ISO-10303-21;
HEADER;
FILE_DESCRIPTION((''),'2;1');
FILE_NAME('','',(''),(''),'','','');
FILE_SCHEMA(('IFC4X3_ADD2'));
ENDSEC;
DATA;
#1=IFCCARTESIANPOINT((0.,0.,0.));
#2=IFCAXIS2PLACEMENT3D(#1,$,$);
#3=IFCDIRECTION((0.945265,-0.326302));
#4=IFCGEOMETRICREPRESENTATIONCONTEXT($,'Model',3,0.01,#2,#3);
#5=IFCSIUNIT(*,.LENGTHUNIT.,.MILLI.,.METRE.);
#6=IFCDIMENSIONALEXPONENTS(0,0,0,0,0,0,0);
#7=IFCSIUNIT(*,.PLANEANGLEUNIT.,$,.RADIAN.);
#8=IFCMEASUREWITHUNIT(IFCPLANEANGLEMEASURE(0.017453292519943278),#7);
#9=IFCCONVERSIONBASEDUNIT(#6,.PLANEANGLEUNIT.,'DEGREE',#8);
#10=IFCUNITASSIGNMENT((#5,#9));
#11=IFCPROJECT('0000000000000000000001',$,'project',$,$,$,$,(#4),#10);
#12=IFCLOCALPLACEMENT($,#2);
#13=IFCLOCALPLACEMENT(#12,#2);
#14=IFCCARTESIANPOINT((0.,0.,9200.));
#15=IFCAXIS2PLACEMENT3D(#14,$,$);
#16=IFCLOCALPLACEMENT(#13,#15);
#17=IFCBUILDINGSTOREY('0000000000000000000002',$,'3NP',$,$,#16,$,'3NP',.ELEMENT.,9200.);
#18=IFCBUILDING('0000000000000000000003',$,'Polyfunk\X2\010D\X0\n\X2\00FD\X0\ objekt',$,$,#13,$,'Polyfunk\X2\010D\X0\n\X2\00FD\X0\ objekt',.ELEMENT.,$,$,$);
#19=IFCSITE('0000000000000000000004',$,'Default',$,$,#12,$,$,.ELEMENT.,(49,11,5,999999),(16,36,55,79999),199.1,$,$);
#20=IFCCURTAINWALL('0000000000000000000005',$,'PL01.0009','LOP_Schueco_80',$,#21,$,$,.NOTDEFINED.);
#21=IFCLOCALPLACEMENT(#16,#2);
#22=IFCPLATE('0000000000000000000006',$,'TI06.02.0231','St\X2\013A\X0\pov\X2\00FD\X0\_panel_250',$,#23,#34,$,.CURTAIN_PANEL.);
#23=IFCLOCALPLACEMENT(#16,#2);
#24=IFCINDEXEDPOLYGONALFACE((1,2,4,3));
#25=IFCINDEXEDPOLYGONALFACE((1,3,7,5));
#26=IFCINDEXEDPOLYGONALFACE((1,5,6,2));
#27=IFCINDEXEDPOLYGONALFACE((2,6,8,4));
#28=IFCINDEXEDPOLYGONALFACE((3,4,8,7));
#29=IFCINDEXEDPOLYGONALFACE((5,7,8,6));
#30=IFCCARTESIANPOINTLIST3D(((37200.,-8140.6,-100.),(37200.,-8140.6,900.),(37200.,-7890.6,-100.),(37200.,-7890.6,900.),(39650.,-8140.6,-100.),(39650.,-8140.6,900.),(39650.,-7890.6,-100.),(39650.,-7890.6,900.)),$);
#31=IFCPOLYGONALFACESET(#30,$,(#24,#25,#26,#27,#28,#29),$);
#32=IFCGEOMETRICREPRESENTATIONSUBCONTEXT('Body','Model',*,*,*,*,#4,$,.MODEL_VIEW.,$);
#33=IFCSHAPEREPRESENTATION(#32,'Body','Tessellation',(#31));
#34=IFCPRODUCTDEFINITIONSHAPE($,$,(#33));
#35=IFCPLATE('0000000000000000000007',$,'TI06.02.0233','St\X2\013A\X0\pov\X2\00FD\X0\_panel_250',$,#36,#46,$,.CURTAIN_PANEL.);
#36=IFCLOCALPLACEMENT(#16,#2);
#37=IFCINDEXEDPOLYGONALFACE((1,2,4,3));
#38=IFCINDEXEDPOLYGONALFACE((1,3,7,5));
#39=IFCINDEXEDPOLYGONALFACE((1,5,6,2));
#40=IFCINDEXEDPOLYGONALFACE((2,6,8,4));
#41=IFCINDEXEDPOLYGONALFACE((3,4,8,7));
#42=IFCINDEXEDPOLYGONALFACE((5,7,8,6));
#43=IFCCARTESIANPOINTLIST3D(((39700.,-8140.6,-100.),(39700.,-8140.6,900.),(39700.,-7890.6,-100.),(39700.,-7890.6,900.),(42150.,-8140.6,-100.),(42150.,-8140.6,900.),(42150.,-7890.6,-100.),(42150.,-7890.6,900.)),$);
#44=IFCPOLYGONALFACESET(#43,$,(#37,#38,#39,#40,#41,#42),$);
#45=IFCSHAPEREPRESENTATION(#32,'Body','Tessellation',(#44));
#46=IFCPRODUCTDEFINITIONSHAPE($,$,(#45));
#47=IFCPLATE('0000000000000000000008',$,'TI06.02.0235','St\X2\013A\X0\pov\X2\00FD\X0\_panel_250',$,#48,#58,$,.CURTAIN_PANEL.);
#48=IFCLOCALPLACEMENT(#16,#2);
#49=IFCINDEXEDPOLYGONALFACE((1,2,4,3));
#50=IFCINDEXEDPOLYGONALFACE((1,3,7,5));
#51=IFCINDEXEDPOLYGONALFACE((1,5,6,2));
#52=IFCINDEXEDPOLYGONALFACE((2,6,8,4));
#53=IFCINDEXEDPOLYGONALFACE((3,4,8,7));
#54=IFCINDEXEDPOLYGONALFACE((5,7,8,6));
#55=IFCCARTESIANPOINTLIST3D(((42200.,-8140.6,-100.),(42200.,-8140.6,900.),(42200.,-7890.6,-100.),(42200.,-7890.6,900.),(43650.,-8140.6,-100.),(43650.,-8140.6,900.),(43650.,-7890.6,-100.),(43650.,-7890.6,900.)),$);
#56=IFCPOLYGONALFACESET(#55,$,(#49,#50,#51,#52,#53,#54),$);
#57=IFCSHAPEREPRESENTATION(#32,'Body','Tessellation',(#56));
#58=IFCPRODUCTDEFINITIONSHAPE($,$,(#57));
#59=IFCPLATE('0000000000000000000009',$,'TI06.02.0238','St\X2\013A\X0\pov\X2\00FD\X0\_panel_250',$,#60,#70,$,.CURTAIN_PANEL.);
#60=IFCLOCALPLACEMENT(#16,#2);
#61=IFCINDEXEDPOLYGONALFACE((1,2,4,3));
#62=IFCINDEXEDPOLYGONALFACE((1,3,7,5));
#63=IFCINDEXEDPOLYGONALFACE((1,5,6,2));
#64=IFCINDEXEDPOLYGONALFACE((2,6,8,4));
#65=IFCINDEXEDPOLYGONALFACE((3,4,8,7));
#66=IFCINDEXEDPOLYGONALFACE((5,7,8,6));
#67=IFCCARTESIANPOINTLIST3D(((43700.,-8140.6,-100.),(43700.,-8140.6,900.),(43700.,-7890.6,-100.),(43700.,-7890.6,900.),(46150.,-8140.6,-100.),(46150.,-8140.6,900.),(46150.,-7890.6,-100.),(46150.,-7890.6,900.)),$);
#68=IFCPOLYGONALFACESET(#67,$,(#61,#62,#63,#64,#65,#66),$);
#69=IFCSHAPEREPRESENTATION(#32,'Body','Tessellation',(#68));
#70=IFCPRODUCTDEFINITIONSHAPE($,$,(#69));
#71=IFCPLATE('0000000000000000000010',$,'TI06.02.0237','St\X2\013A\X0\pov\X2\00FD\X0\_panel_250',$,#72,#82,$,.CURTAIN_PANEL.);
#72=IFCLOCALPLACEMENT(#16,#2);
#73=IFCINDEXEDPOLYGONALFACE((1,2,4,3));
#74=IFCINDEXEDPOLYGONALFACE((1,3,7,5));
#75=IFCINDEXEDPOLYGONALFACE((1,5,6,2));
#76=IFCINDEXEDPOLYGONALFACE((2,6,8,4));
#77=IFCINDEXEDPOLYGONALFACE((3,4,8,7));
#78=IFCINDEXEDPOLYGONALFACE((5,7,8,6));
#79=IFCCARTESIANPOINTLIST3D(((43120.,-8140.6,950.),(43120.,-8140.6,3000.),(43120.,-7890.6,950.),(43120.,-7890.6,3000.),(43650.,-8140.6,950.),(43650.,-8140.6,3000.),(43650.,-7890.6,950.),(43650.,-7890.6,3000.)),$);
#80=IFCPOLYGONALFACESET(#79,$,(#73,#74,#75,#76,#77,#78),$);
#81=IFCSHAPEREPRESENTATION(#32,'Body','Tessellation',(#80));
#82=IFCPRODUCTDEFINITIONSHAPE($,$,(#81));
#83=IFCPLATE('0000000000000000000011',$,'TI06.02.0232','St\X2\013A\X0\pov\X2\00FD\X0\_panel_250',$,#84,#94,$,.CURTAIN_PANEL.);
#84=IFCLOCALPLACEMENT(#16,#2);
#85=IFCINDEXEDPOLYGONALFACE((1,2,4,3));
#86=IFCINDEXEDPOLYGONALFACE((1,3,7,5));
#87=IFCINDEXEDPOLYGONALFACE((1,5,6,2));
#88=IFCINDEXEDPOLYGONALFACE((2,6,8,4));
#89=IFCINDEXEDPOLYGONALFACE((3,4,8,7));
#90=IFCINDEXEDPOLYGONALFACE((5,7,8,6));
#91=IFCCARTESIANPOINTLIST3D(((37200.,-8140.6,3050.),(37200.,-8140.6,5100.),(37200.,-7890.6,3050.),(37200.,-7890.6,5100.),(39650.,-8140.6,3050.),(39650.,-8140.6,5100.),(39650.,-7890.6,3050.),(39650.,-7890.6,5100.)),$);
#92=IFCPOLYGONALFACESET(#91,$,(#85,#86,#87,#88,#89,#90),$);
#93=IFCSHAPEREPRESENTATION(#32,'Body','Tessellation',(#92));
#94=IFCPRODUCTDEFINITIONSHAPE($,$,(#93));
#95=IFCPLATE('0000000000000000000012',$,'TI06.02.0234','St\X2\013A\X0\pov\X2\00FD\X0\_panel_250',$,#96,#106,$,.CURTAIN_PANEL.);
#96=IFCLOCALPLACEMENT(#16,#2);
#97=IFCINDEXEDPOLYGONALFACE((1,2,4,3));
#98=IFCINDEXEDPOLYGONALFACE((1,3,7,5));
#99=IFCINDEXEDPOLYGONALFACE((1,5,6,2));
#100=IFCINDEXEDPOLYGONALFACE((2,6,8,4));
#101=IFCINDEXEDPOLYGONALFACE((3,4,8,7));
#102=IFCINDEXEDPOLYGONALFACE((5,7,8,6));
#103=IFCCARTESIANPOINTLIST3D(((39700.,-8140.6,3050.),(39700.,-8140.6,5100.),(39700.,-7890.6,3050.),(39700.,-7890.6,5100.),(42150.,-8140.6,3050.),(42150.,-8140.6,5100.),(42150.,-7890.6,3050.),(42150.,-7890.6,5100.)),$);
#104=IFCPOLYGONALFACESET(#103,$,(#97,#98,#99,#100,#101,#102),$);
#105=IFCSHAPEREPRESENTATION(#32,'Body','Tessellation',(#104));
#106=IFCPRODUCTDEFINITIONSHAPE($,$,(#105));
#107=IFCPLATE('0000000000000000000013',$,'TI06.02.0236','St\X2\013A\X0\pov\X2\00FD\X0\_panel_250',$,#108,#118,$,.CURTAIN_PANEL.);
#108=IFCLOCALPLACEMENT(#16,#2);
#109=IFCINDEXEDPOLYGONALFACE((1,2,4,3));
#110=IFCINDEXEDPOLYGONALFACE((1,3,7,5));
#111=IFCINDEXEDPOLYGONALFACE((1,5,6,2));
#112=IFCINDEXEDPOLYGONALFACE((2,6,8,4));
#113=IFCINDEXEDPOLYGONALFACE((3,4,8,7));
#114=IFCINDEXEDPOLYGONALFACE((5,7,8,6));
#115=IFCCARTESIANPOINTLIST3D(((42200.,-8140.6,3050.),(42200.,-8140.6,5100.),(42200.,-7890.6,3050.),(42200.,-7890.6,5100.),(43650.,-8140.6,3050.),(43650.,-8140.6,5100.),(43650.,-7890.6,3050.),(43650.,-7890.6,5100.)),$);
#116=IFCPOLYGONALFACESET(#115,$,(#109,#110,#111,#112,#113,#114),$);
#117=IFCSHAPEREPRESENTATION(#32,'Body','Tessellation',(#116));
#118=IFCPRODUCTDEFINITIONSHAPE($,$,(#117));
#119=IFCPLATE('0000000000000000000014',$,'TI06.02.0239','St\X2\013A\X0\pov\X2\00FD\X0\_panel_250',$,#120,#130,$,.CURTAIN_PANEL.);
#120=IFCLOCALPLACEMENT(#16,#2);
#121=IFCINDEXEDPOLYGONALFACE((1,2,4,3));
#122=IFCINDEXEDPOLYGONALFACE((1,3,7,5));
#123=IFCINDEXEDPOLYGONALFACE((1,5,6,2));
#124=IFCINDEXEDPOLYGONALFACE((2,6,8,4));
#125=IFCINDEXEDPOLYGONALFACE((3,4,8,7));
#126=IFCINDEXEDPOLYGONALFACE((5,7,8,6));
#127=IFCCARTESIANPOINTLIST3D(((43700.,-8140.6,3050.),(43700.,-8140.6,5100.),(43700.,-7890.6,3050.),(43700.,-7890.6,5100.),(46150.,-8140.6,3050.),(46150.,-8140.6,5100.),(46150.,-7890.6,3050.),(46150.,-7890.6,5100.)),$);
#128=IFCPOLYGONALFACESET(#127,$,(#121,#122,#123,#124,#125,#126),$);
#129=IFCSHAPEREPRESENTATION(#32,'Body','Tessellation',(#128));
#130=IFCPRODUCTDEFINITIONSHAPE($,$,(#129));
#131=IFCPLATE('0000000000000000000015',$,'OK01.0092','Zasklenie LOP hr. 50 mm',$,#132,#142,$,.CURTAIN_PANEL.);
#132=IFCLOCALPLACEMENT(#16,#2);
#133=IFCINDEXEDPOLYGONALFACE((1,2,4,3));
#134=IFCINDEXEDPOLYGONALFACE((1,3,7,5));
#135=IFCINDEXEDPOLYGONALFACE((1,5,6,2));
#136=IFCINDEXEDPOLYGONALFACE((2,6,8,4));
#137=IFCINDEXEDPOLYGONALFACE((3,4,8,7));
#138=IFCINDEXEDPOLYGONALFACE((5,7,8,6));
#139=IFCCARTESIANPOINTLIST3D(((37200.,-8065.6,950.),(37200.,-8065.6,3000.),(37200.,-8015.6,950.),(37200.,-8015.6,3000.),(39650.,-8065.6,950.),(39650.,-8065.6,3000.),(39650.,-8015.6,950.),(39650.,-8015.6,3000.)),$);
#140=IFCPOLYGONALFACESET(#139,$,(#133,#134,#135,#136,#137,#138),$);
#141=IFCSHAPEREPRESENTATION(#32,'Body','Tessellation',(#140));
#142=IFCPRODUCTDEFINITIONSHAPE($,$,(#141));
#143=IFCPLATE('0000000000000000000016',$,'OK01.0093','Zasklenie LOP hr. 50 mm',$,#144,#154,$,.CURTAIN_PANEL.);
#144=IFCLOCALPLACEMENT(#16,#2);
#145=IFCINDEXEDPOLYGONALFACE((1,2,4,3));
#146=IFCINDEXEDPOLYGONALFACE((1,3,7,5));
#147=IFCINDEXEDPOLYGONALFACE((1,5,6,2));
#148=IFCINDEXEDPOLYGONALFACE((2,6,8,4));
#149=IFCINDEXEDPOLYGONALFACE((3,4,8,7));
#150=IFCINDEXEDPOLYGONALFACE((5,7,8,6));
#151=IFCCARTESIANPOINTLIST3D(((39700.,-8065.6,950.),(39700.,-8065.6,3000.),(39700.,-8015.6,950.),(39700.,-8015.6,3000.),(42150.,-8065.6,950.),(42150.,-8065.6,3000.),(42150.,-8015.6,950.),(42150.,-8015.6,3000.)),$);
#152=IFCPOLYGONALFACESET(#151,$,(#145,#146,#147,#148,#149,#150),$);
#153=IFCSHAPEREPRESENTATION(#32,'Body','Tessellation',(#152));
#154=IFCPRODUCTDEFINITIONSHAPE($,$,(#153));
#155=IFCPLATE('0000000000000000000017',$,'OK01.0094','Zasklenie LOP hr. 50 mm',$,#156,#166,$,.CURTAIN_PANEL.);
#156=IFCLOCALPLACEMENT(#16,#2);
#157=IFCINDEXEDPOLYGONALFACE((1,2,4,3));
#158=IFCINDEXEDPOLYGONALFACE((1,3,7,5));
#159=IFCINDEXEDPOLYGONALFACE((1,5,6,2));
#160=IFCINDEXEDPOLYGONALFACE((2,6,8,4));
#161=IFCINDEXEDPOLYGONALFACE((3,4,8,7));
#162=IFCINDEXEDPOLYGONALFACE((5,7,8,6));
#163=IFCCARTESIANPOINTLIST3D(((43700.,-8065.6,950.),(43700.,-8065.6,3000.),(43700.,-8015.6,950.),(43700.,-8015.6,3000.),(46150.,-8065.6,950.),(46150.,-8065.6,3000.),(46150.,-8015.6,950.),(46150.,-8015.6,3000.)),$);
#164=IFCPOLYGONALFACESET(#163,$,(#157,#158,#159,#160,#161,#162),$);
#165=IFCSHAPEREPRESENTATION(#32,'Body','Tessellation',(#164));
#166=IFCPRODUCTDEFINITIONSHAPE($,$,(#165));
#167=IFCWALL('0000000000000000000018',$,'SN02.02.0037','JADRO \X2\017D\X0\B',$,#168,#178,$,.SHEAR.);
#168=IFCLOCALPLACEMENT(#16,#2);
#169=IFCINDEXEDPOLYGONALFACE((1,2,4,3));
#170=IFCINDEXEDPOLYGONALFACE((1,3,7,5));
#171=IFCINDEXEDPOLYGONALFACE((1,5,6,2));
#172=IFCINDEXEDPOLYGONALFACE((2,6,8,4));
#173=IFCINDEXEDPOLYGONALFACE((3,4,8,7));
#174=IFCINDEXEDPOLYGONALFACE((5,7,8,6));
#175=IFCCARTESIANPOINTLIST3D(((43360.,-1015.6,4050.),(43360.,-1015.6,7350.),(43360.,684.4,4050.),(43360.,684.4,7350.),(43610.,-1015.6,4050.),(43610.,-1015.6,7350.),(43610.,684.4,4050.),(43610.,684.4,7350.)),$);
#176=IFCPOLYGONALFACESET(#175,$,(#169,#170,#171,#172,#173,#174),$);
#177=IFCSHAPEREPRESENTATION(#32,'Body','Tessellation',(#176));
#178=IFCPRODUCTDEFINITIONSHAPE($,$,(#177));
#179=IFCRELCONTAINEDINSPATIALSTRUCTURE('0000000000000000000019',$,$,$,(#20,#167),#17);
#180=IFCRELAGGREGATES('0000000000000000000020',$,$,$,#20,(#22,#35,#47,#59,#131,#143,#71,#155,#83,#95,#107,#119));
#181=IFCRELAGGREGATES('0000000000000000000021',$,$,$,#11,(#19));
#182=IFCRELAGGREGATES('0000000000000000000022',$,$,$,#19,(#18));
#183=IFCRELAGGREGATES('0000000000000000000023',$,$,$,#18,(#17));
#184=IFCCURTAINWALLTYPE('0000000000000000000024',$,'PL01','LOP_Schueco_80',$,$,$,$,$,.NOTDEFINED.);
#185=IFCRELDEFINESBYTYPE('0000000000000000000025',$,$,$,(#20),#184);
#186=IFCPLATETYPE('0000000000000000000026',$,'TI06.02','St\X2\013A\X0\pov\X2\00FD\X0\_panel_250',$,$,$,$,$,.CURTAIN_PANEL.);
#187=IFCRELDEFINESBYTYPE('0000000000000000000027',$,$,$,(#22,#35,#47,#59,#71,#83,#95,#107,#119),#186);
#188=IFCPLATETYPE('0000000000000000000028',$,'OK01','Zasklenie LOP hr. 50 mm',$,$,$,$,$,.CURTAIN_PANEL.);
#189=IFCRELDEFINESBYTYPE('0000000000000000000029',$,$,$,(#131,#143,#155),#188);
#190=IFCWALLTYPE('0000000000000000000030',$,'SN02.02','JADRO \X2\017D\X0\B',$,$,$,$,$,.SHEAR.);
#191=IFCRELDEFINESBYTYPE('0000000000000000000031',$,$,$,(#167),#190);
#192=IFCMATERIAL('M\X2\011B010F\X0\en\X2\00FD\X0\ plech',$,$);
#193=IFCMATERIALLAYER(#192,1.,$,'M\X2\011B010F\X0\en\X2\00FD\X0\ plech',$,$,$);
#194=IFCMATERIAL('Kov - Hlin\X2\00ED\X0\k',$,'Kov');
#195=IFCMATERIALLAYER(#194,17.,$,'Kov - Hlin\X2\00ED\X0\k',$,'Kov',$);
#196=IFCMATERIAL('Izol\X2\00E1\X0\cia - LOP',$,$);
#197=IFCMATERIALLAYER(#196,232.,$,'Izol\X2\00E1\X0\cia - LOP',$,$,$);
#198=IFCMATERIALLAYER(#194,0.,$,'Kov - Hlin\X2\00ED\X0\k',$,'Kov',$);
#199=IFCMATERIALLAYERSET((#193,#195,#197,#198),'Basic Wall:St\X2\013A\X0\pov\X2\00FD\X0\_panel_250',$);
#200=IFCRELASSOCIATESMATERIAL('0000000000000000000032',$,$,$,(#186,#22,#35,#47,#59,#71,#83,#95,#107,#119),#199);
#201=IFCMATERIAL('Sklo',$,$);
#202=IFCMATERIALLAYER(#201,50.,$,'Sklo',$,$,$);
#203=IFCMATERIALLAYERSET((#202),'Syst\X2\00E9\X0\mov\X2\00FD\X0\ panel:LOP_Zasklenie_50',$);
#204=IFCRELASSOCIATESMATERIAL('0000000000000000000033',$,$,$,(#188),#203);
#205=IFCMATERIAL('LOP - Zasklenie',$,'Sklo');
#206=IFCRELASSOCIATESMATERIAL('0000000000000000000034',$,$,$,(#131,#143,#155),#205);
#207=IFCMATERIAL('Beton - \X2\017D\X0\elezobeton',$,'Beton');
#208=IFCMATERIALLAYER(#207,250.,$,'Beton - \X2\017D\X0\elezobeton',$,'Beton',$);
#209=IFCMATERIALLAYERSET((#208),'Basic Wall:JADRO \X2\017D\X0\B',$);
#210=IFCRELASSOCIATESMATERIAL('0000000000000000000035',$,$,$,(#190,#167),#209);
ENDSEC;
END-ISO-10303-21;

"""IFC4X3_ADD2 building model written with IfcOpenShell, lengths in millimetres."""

from ifc_helpers import new_model, entity, si_unit, converted_unit, direction, frame, frame_2d, origin, origin_2d_with_axis, place, context, subcontext, project, spatial, polyline, rectangle, extrude, clip, bounded_halfspace, source, transform, mapped, material, layer, layer_set, layer_usage, type_object, type_shapes, element, aggregate, save


model = new_model("IFC4X3_ADD2")

# Units and contexts
model_context = context("Model", 3, precision=0.01, world=origin(), true_north=direction((0.945265, -0.326302)))
body_context = subcontext(model_context, "Body", "Model", "MODEL_VIEW")
ifc_project = project(units=[si_unit("LENGTHUNIT", "METRE", prefix="MILLI"), converted_unit("PLANEANGLEUNIT", "DEGREE", entity("IfcPlaneAngleMeasure", 0.017453292519943278), si_unit("PLANEANGLEUNIT", "RADIAN"), dimensions=[0, 0, 0, 0, 0, 0, 0])], contexts=[model_context])

# Site, building, storey
site_placement = place(None, origin())
site = spatial("IfcSite", under=ifc_project, at=site_placement, Name="Default", CompositionType="ELEMENT", RefLatitude=(49, 11, 5, 999999), RefLongitude=(16, 36, 55, 79999), RefElevation=199.1)
building_placement = place(site_placement, origin())
building = spatial("IfcBuilding", under=site, at=building_placement, Name="Polyfunkčný objekt", LongName="Polyfunkčný objekt", CompositionType="ELEMENT")
storey_placement = place(building_placement, frame((0.0, 0.0, 9200.0)))
storey = spatial("IfcBuildingStorey", under=building, at=storey_placement, Name="3NP", LongName="3NP", CompositionType="ELEMENT", Elevation=9200.0)

# Curtain wall, plates
curtain_wall_type = type_object("IfcCurtainWallType", Name="PL01", Description="LOP_Schueco_80", PredefinedType="NOTDEFINED")
curtain_wall_placement = place(storey_placement, frame((0.0, 0.0, -9200.0)))
curtain_wall = element("IfcCurtainWall", 1, at=curtain_wall_placement, inside=storey, type_object=curtain_wall_type, Name="PL01.0009", Description="LOP_Schueco_80", PredefinedType="NOTDEFINED")
ifc_material_1 = material(Name="Měďený plech")
ifc_layer_1 = layer(ifc_material_1, 1.0, Name="Měďený plech")
ifc_material_2 = material(Name="Kov - Hliník", Category="Kov")
ifc_layer_2 = layer(ifc_material_2, 17.0, Name="Kov - Hliník", Category="Kov")
ifc_material_3 = material(Name="Izolácia - LOP")
ifc_layer_3 = layer(ifc_material_3, 232.0, Name="Izolácia - LOP")
ifc_layer_4 = layer(ifc_material_2, 0.0, Name="Kov - Hliník", Category="Kov")
ifc_layer_set_1 = layer_set([ifc_layer_1, ifc_layer_2, ifc_layer_3, ifc_layer_4], Name="Basic Wall:Stĺpový_panel_250")
ifc_layer_usage_1 = layer_usage(ifc_layer_set_1, "AXIS2", "POSITIVE", -125.0)
plate_type_1 = type_object("IfcPlateType", Name="TI06.02", Description="Stĺpový_panel_250", PredefinedType="CURTAIN_PANEL", material=ifc_layer_set_1)
plate_1_placement = place(storey_placement, frame((37200.0, -8015.6, -100.0)))
plate_1 = element("IfcPlate", 2, at=plate_1_placement, type_object=plate_type_1, material=ifc_layer_usage_1, Name="TI06.02.0231", Description="Stĺpový_panel_250", PredefinedType="CURTAIN_PANEL", context=body_context, shape_type="SweptSolid", body=[
    extrude(rectangle(XDim=250.0, YDim=2450.0, at=frame_2d((0.0, 0.0), x_axis=(1.0, 0.0))), frame((1225.0, 0.0, 0.0), z_axis=(0.0, 0.0, 1.0), x_axis=(0.0, 1.0, 0.0)), (0.0, 0.0, 1.0), 1000.0),
])
ifc_layer_usage_2 = layer_usage(ifc_layer_set_1, "AXIS2", "POSITIVE", -125.0)
plate_2_placement = place(storey_placement, frame((39700.0, -8015.6, -100.0)))
plate_2 = element("IfcPlate", 3, at=plate_2_placement, type_object=plate_type_1, material=ifc_layer_usage_2, Name="TI06.02.0233", Description="Stĺpový_panel_250", PredefinedType="CURTAIN_PANEL", context=body_context, shape_type="SweptSolid", body=[
    extrude(rectangle(XDim=250.0, YDim=2450.0, at=frame_2d((0.0, 0.0), x_axis=(1.0, 0.0))), frame((1225.0, 0.0, 0.0), z_axis=(0.0, 0.0, 1.0), x_axis=(0.0, 1.0, 0.0)), (0.0, 0.0, 1.0), 1000.0),
])
ifc_layer_usage_3 = layer_usage(ifc_layer_set_1, "AXIS2", "POSITIVE", -125.0)
plate_3_placement = place(storey_placement, frame((42200.0, -8015.6, -100.0)))
plate_3 = element("IfcPlate", 4, at=plate_3_placement, type_object=plate_type_1, material=ifc_layer_usage_3, Name="TI06.02.0235", Description="Stĺpový_panel_250", PredefinedType="CURTAIN_PANEL", context=body_context, shape_type="SweptSolid", body=[
    extrude(rectangle(XDim=250.0, YDim=1450.0, at=frame_2d((0.0, 0.0), x_axis=(1.0, 0.0))), frame((725.0, 0.0, 0.0), z_axis=(0.0, 0.0, 1.0), x_axis=(0.0, 1.0, 0.0)), (0.0, 0.0, 1.0), 1000.0),
])
ifc_layer_usage_4 = layer_usage(ifc_layer_set_1, "AXIS2", "POSITIVE", -125.0)
plate_4_placement = place(storey_placement, frame((43700.0, -8015.6, -100.0)))
plate_4 = element("IfcPlate", 5, at=plate_4_placement, type_object=plate_type_1, material=ifc_layer_usage_4, Name="TI06.02.0238", Description="Stĺpový_panel_250", PredefinedType="CURTAIN_PANEL", context=body_context, shape_type="SweptSolid", body=[
    extrude(rectangle(XDim=250.0, YDim=2450.0, at=frame_2d((0.0, 0.0), x_axis=(1.0, 0.0))), frame((1225.0, 0.0, 0.0), z_axis=(0.0, 0.0, 1.0), x_axis=(0.0, 1.0, 0.0)), (0.0, 0.0, 1.0), 1000.0),
])
ifc_layer_usage_5 = layer_usage(ifc_layer_set_1, "AXIS2", "POSITIVE", -125.0)
plate_5_placement = place(storey_placement, frame((43120.0, -8015.6, 950.0)))
plate_5 = element("IfcPlate", 6, at=plate_5_placement, type_object=plate_type_1, material=ifc_layer_usage_5, Name="TI06.02.0237", Description="Stĺpový_panel_250", PredefinedType="CURTAIN_PANEL", context=body_context, shape_type="SweptSolid", body=[
    extrude(rectangle(XDim=250.0, YDim=530.0, at=frame_2d((0.0, 0.0), x_axis=(1.0, 0.0))), frame((265.0, 0.0, 0.0), z_axis=(0.0, 0.0, 1.0), x_axis=(0.0, 1.0, 0.0)), (0.0, 0.0, 1.0), 2050.0),
])
ifc_layer_usage_6 = layer_usage(ifc_layer_set_1, "AXIS2", "POSITIVE", -125.0)
plate_6_placement = place(storey_placement, frame((37200.0, -8015.6, 3050.0)))
plate_6 = element("IfcPlate", 7, at=plate_6_placement, type_object=plate_type_1, material=ifc_layer_usage_6, Name="TI06.02.0232", Description="Stĺpový_panel_250", PredefinedType="CURTAIN_PANEL", context=body_context, shape_type="SweptSolid", body=[
    extrude(rectangle(XDim=250.0, YDim=2450.0, at=frame_2d((0.0, 0.0), x_axis=(1.0, 0.0))), frame((1225.0, 0.0, 0.0), z_axis=(0.0, 0.0, 1.0), x_axis=(0.0, 1.0, 0.0)), (0.0, 0.0, 1.0), 2050.0),
])
ifc_layer_usage_7 = layer_usage(ifc_layer_set_1, "AXIS2", "POSITIVE", -125.0)
plate_7_placement = place(storey_placement, frame((39700.0, -8015.6, 3050.0)))
plate_7 = element("IfcPlate", 8, at=plate_7_placement, type_object=plate_type_1, material=ifc_layer_usage_7, Name="TI06.02.0234", Description="Stĺpový_panel_250", PredefinedType="CURTAIN_PANEL", context=body_context, shape_type="SweptSolid", body=[
    extrude(rectangle(XDim=250.0, YDim=2450.0, at=frame_2d((0.0, 0.0), x_axis=(1.0, 0.0))), frame((1225.0, 0.0, 0.0), z_axis=(0.0, 0.0, 1.0), x_axis=(0.0, 1.0, 0.0)), (0.0, 0.0, 1.0), 2050.0),
])
ifc_layer_usage_8 = layer_usage(ifc_layer_set_1, "AXIS2", "POSITIVE", -125.0)
plate_8_placement = place(storey_placement, frame((42200.0, -8015.6, 3050.0)))
plate_8 = element("IfcPlate", 9, at=plate_8_placement, type_object=plate_type_1, material=ifc_layer_usage_8, Name="TI06.02.0236", Description="Stĺpový_panel_250", PredefinedType="CURTAIN_PANEL", context=body_context, shape_type="SweptSolid", body=[
    extrude(rectangle(XDim=250.0, YDim=1450.0, at=frame_2d((0.0, 0.0), x_axis=(1.0, 0.0))), frame((725.0, 0.0, 0.0), z_axis=(0.0, 0.0, 1.0), x_axis=(0.0, 1.0, 0.0)), (0.0, 0.0, 1.0), 2050.0),
])
ifc_layer_usage_9 = layer_usage(ifc_layer_set_1, "AXIS2", "POSITIVE", -125.0)
plate_9_placement = place(storey_placement, frame((43700.0, -8015.6, 3050.0)))
plate_9 = element("IfcPlate", 10, at=plate_9_placement, type_object=plate_type_1, material=ifc_layer_usage_9, Name="TI06.02.0239", Description="Stĺpový_panel_250", PredefinedType="CURTAIN_PANEL", context=body_context, shape_type="SweptSolid", body=[
    extrude(rectangle(XDim=250.0, YDim=2450.0, at=frame_2d((0.0, 0.0), x_axis=(1.0, 0.0))), frame((1225.0, 0.0, 0.0), z_axis=(0.0, 0.0, 1.0), x_axis=(0.0, 1.0, 0.0)), (0.0, 0.0, 1.0), 2050.0),
])
ifc_material_4 = material(Name="LOP - Zasklenie", Category="Sklo")
ifc_material_5 = material(Name="Sklo")
ifc_layer_5 = layer(ifc_material_5, 50.0, Name="Sklo")
ifc_layer_set_2 = layer_set([ifc_layer_5], Name="Systémový panel:LOP_Zasklenie_50")
plate_type_2 = type_object("IfcPlateType", Name="OK01", Description="Zasklenie LOP hr. 50 mm", PredefinedType="CURTAIN_PANEL", material=ifc_layer_set_2)
shared_shape_1 = source(origin(), body_context, "Body", "SweptSolid", [
    extrude(rectangle(XDim=50.0, YDim=2450.0, at=origin_2d_with_axis()), frame((0.0, -25.0, 0.0), z_axis=(0.0, 0.0, 1.0), x_axis=(0.0, 1.0, 0.0)), (0.0, 0.0, 1.0), 2050.0),
])
type_shapes(plate_type_2, [shared_shape_1])
plate_10_placement = place(curtain_wall_placement, frame((38425.0, -8015.6, 10150.0)))
plate_10 = element("IfcPlate", 11, at=plate_10_placement, type_object=plate_type_2, material=ifc_material_4, Name="OK01.0092", Description="Zasklenie LOP hr. 50 mm", PredefinedType="CURTAIN_PANEL", context=body_context, shape_type="MappedRepresentation", body=[
    mapped(shared_shape_1, transform((0.0, 0.0, 0.0), scale=1.0)),
])
plate_11_placement = place(curtain_wall_placement, frame((40925.0, -8015.6, 10150.0)))
plate_11 = element("IfcPlate", 12, at=plate_11_placement, type_object=plate_type_2, material=ifc_material_4, Name="OK01.0093", Description="Zasklenie LOP hr. 50 mm", PredefinedType="CURTAIN_PANEL", context=body_context, shape_type="MappedRepresentation", body=[
    mapped(shared_shape_1, transform((0.0, 0.0, 0.0), scale=1.0)),
])
plate_12_placement = place(curtain_wall_placement, frame((44925.0, -8015.6, 10150.0)))
plate_12 = element("IfcPlate", 13, at=plate_12_placement, type_object=plate_type_2, material=ifc_material_4, Name="OK01.0094", Description="Zasklenie LOP hr. 50 mm", PredefinedType="CURTAIN_PANEL", context=body_context, shape_type="MappedRepresentation", body=[
    mapped(shared_shape_1, transform((0.0, 0.0, 0.0), scale=1.0)),
])

# Wall
ifc_material_6 = material(Name="Beton - Železobeton", Category="Beton")
ifc_layer_6 = layer(ifc_material_6, 250.0, Name="Beton - Železobeton", Category="Beton")
ifc_layer_set_3 = layer_set([ifc_layer_6], Name="Basic Wall:JADRO ŽB")
wall_type = type_object("IfcWallType", Name="SN02.02", Description="JADRO ŽB", PredefinedType="SHEAR", material=ifc_layer_set_3)
wall_1_placement = place(storey_placement, frame((43485.0, 684.4, 4050.0), z_axis=(0.0, 0.0, 1.0), x_axis=(0.0, -1.0, 0.0)))
element("IfcWall", 14, at=wall_1_placement, inside=storey, type_object=wall_type, material=ifc_layer_set_3, Name="SN02.02.0037", Description="JADRO ŽB", PredefinedType="SHEAR", context=body_context, shape_type="Clipping", body=[
    clip(clip(extrude(rectangle(XDim=1700.0, YDim=250.0, at=frame_2d((850.0, 0.0), x_axis=(-1.0, 0.0))), origin(), (0.0, 0.0, 1.0), 3300.0), bounded_halfspace(frame((1700.0, -125.0, 0.0), z_axis=(0.0, 0.0, 1.0), x_axis=(0.0, -1.0, 0.0)), True, frame((1700.0, -125.0, 0.0)), polyline([(0.0, 0.0), (0.0, 250.0), (-1700.0, 250.0), (-1700.0, 0.0), (0.0, 0.0)]))), bounded_halfspace(frame((0.0, -125.0, 3300.0), z_axis=(0.0, 0.0, -1.0), x_axis=(1.0, 0.0, 0.0)), True, frame((0.0, -125.0, 3300.0)), polyline([(0.0, 0.0), (1700.0, 0.0), (1700.0, 250.0), (0.0, 250.0), (0.0, 0.0)]))),
])

aggregate(curtain_wall, [plate_1, plate_2, plate_3, plate_4, plate_10, plate_11, plate_5, plate_12, plate_6, plate_7, plate_8, plate_9])

save(model, "model.ifc")
